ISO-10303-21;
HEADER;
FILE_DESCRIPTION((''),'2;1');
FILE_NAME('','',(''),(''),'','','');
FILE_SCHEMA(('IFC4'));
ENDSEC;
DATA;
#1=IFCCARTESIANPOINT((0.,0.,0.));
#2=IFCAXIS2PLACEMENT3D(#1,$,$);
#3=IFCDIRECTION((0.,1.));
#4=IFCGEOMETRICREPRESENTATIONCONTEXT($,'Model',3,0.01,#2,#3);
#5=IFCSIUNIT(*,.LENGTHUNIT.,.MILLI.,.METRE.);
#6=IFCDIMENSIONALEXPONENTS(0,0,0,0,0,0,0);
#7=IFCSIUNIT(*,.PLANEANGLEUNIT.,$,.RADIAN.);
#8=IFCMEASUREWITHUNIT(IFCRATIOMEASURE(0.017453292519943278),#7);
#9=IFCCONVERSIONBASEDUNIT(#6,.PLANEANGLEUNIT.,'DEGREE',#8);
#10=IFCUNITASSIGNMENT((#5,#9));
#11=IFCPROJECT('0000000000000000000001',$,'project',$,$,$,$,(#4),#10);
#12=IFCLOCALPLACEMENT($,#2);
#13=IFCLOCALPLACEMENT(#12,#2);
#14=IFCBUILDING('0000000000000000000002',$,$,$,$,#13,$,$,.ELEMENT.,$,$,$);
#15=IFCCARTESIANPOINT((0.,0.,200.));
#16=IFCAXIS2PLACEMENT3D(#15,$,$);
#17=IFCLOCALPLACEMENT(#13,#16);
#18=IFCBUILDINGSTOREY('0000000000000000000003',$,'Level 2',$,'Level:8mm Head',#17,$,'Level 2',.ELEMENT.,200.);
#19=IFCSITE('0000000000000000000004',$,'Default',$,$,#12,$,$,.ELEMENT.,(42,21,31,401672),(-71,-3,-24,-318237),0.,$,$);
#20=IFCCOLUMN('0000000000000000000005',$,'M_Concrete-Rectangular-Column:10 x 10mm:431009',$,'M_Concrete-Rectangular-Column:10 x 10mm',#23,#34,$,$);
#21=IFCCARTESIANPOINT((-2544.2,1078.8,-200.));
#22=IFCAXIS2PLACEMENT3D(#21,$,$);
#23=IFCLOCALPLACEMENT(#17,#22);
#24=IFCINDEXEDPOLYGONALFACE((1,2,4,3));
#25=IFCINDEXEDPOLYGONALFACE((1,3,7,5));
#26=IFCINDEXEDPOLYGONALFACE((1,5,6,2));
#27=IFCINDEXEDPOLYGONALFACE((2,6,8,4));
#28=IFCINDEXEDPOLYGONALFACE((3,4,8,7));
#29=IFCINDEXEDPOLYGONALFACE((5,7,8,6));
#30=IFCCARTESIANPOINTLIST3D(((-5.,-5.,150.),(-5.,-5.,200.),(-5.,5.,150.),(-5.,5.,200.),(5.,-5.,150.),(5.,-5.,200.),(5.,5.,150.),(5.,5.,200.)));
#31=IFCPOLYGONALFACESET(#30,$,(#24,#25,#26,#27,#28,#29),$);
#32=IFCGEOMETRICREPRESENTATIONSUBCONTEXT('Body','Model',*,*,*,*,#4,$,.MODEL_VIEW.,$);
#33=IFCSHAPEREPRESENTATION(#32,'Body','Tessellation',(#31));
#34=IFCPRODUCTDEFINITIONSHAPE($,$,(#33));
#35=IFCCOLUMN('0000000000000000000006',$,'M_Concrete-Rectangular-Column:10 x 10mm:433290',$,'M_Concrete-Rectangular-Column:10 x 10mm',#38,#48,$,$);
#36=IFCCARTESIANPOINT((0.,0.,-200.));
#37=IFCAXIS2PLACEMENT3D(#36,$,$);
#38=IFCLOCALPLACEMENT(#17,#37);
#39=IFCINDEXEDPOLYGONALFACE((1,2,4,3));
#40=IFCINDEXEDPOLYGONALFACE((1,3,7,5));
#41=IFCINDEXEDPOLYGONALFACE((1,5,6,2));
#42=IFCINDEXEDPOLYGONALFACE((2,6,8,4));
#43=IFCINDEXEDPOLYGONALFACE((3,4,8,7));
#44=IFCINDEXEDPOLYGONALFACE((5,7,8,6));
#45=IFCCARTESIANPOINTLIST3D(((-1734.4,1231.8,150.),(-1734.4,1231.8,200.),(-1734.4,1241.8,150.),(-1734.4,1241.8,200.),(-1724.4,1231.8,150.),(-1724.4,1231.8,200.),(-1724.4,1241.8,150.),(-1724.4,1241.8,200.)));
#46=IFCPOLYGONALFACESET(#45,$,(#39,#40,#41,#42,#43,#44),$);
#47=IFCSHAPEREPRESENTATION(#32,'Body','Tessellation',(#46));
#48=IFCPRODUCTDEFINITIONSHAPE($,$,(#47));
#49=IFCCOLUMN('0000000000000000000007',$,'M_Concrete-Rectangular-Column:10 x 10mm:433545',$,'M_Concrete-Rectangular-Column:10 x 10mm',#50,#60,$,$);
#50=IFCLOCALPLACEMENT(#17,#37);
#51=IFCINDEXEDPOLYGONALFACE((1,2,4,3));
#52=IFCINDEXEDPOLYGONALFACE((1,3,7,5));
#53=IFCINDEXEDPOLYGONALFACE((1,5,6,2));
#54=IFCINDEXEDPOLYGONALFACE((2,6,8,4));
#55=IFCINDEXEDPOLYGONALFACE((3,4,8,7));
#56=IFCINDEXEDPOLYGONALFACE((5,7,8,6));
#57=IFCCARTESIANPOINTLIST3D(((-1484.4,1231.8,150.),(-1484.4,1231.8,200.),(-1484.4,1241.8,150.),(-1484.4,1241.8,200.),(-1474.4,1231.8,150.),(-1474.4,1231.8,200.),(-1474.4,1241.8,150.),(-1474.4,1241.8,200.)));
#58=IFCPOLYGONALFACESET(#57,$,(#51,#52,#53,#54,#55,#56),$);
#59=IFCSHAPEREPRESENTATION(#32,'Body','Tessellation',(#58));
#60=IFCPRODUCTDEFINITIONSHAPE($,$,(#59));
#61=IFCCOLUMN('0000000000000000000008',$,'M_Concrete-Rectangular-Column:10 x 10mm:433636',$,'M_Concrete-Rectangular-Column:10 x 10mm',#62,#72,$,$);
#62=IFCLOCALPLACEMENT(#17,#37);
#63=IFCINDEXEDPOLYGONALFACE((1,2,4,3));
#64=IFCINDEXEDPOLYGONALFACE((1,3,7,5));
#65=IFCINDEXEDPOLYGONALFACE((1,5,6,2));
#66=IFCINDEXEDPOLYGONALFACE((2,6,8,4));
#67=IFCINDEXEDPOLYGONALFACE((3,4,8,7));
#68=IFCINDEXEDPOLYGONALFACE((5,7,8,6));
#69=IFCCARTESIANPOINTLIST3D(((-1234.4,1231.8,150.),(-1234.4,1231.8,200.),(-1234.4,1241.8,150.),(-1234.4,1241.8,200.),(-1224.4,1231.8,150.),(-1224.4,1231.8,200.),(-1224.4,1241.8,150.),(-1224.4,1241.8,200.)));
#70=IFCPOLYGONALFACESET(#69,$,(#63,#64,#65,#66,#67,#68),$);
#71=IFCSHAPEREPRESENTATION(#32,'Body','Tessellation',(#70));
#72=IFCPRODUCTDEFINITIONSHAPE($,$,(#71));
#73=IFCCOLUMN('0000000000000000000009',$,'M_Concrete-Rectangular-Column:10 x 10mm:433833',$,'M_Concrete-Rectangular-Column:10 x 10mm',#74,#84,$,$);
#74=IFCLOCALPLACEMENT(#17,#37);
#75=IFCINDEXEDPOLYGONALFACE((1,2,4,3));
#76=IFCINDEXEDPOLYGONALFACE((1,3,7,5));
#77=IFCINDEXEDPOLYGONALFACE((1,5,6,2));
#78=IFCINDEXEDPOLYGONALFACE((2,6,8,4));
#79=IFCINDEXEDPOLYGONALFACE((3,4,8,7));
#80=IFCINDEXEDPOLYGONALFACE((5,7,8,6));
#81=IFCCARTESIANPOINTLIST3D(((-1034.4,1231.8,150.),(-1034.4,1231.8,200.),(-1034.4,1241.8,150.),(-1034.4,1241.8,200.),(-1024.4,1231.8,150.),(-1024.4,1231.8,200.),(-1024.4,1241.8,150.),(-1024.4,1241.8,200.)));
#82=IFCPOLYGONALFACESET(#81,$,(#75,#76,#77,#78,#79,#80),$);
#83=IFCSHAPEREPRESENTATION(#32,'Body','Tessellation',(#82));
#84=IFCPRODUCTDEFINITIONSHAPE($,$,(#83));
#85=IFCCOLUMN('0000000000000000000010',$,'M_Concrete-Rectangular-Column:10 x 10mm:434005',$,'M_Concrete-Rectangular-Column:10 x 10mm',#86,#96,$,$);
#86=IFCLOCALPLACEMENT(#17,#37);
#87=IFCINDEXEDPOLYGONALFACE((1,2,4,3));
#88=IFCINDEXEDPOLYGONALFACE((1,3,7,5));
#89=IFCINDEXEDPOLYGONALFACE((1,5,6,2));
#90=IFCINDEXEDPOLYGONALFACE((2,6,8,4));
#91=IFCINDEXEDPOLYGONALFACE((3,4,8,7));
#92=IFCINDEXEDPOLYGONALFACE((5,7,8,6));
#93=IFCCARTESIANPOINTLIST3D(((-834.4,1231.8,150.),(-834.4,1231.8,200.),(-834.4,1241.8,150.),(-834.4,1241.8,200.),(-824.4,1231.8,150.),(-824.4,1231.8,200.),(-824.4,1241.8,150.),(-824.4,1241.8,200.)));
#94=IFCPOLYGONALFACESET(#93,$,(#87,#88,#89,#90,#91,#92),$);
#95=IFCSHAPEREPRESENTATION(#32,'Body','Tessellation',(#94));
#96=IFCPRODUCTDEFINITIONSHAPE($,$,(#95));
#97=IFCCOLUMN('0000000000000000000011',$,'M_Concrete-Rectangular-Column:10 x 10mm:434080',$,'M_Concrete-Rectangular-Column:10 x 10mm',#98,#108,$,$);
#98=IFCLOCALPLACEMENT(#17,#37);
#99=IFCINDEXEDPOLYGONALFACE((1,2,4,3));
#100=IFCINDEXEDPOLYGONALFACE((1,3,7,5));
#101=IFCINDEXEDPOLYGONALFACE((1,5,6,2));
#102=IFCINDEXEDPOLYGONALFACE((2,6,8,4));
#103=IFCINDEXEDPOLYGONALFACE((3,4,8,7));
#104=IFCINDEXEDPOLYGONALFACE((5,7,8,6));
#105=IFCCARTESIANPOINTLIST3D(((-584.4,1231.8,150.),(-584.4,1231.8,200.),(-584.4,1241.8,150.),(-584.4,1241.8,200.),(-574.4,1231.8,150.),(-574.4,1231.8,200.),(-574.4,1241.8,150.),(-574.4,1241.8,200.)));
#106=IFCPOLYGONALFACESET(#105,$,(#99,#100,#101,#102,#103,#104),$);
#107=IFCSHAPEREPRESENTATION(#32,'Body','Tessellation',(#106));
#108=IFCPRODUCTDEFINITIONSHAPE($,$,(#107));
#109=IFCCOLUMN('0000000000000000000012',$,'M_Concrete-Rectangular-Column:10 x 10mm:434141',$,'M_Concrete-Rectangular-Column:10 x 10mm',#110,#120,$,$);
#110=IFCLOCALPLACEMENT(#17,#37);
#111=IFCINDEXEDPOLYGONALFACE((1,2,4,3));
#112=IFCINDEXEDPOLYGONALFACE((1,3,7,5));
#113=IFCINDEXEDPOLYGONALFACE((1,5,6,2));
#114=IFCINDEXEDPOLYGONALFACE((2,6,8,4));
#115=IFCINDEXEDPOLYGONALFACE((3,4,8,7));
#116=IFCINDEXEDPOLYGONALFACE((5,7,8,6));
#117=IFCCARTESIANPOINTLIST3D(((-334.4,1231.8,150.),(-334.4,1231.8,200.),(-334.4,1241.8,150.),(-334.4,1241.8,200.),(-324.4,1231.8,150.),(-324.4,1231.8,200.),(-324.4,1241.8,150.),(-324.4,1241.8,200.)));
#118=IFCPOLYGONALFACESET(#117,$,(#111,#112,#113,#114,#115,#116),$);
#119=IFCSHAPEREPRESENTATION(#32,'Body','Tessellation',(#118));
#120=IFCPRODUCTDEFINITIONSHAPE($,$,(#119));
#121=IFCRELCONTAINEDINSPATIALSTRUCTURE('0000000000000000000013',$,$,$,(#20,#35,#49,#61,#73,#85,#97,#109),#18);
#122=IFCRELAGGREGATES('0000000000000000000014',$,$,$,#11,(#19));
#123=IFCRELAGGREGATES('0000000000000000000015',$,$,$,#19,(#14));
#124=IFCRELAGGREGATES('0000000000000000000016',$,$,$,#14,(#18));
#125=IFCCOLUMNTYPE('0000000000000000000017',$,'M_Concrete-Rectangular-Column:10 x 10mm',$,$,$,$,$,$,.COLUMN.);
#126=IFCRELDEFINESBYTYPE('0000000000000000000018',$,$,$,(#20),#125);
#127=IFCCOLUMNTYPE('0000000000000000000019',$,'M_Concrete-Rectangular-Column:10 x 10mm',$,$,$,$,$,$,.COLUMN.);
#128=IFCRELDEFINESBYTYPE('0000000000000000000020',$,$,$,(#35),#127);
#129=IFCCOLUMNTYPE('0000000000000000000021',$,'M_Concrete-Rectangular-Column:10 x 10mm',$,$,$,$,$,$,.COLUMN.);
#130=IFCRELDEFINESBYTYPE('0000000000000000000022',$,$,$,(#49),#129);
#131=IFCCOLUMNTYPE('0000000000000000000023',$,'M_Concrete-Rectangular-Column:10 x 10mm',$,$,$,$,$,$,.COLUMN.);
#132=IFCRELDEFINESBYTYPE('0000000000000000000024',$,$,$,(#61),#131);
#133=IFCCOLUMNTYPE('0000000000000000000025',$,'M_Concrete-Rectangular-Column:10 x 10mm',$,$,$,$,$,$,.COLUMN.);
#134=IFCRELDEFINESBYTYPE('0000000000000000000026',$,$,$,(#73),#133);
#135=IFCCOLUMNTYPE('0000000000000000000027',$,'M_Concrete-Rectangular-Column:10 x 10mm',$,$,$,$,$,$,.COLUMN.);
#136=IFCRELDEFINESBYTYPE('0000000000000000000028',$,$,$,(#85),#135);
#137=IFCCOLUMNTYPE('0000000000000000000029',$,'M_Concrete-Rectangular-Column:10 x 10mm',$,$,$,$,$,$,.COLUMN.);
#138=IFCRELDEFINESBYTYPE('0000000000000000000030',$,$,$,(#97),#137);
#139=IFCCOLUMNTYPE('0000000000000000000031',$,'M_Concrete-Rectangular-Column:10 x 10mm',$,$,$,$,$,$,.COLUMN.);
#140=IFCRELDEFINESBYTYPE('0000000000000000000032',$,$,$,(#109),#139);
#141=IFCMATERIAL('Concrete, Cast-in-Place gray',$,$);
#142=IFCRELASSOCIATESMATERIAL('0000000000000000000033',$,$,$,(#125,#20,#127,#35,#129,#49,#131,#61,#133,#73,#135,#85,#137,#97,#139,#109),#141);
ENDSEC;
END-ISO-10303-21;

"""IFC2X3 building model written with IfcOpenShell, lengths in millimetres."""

from ifc_helpers import new_model, entity, si_unit, converted_unit, direction, frame, frame_2d, origin, origin_2d_with_axis, place, context, subcontext, project, spatial, rectangle, extrude, source, transform, mapped, material, type_object, type_shapes, element, save


model = new_model("IFC2X3")

# Units and contexts
model_context = context("Model", 3, precision=0.01, world=origin(), true_north=direction((0.0, 1.0)))
body_context = subcontext(model_context, "Body", "Model", "MODEL_VIEW")
ifc_project = project(units=[si_unit("LENGTHUNIT", "METRE", prefix="MILLI"), converted_unit("PLANEANGLEUNIT", "DEGREE", entity("IfcRatioMeasure", 0.017453292519943278), si_unit("PLANEANGLEUNIT", "RADIAN"), dimensions=[0, 0, 0, 0, 0, 0, 0])], contexts=[model_context])

# Site, building, storey
site_placement = place(None, origin())
site = spatial("IfcSite", under=ifc_project, at=site_placement, Name="Default", CompositionType="ELEMENT", RefLatitude=(42, 21, 31, 401672), RefLongitude=(-71, -3, -24, -318237), RefElevation=0.0)
building_placement = place(site_placement, origin())
building = spatial("IfcBuilding", under=site, at=building_placement, CompositionType="ELEMENT")
storey_placement = place(building_placement, frame((0.0, 0.0, 200.0)))
storey = spatial("IfcBuildingStorey", under=building, at=storey_placement, Name="Level 2", ObjectType="Level:8mm Head", LongName="Level 2", CompositionType="ELEMENT", Elevation=200.0)

# Columns
ifc_material = material(Name="Concrete, Cast-in-Place gray")
column_type_1 = type_object("IfcColumnType", Name="M_Concrete-Rectangular-Column:10 x 10mm", PredefinedType="COLUMN", material=ifc_material)
shared_shape_1 = source(origin(), body_context, "Body", "SweptSolid", [
    extrude(rectangle(XDim=10.0, YDim=10.0, at=origin_2d_with_axis()), frame((0.0, 0.0, 150.0), z_axis=(0.0, 0.0, 1.0), x_axis=(0.0, -1.0, 0.0)), (0.0, 0.0, 1.0), 50.0),
])
type_shapes(column_type_1, [shared_shape_1])
column_1_placement = place(storey_placement, frame((-2544.2, 1078.8, -200.0)))
element("IfcColumn", 1, at=column_1_placement, inside=storey, type_object=column_type_1, material=ifc_material, Name="M_Concrete-Rectangular-Column:10 x 10mm:431009", ObjectType="M_Concrete-Rectangular-Column:10 x 10mm", context=body_context, shape_type="MappedRepresentation", body=[
    mapped(shared_shape_1, transform((0.0, 0.0, 0.0), scale=1.0)),
])
column_type_2 = type_object("IfcColumnType", Name="M_Concrete-Rectangular-Column:10 x 10mm", PredefinedType="COLUMN", material=ifc_material)
shared_shape_2 = source(origin(), body_context, "Body", "SweptSolid", [
    extrude(rectangle(XDim=10.0, YDim=10.0, at=frame_2d((0.0, 0.0), x_axis=(1.0, 0.0))), frame((-1729.4, 1236.8, 150.0), z_axis=(0.0, 0.0, 1.0), x_axis=(0.0, -1.0, 0.0)), (0.0, 0.0, 1.0), 50.0),
])
type_shapes(column_type_2, [shared_shape_2])
column_2_placement = place(storey_placement, frame((0.0, 0.0, -200.0)))
element("IfcColumn", 2, at=column_2_placement, inside=storey, type_object=column_type_2, material=ifc_material, Name="M_Concrete-Rectangular-Column:10 x 10mm:433290", ObjectType="M_Concrete-Rectangular-Column:10 x 10mm", context=body_context, shape_type="MappedRepresentation", body=[
    mapped(shared_shape_2, transform((0.0, 0.0, 0.0), scale=1.0)),
])
column_type_3 = type_object("IfcColumnType", Name="M_Concrete-Rectangular-Column:10 x 10mm", PredefinedType="COLUMN", material=ifc_material)
shared_shape_3 = source(origin(), body_context, "Body", "SweptSolid", [
    extrude(rectangle(XDim=10.0, YDim=10.0, at=frame_2d((0.0, 0.0), x_axis=(1.0, 0.0))), frame((-1479.4, 1236.8, 150.0), z_axis=(0.0, 0.0, 1.0), x_axis=(0.0, -1.0, 0.0)), (0.0, 0.0, 1.0), 50.0),
])
type_shapes(column_type_3, [shared_shape_3])
column_3_placement = place(storey_placement, frame((0.0, 0.0, -200.0)))
element("IfcColumn", 3, at=column_3_placement, inside=storey, type_object=column_type_3, material=ifc_material, Name="M_Concrete-Rectangular-Column:10 x 10mm:433545", ObjectType="M_Concrete-Rectangular-Column:10 x 10mm", context=body_context, shape_type="MappedRepresentation", body=[
    mapped(shared_shape_3, transform((0.0, 0.0, 0.0), scale=1.0)),
])
column_type_4 = type_object("IfcColumnType", Name="M_Concrete-Rectangular-Column:10 x 10mm", PredefinedType="COLUMN", material=ifc_material)
shared_shape_4 = source(origin(), body_context, "Body", "SweptSolid", [
    extrude(rectangle(XDim=10.0, YDim=10.0, at=frame_2d((0.0, 0.0), x_axis=(1.0, 0.0))), frame((-1229.4, 1236.8, 150.0), z_axis=(0.0, 0.0, 1.0), x_axis=(0.0, -1.0, 0.0)), (0.0, 0.0, 1.0), 50.0),
])
type_shapes(column_type_4, [shared_shape_4])
column_4_placement = place(storey_placement, frame((0.0, 0.0, -200.0)))
element("IfcColumn", 4, at=column_4_placement, inside=storey, type_object=column_type_4, material=ifc_material, Name="M_Concrete-Rectangular-Column:10 x 10mm:433636", ObjectType="M_Concrete-Rectangular-Column:10 x 10mm", context=body_context, shape_type="MappedRepresentation", body=[
    mapped(shared_shape_4, transform((0.0, 0.0, 0.0), scale=1.0)),
])
column_type_5 = type_object("IfcColumnType", Name="M_Concrete-Rectangular-Column:10 x 10mm", PredefinedType="COLUMN", material=ifc_material)
shared_shape_5 = source(origin(), body_context, "Body", "SweptSolid", [
    extrude(rectangle(XDim=10.0, YDim=10.0, at=origin_2d_with_axis()), frame((-1029.4, 1236.8, 150.0), z_axis=(0.0, 0.0, 1.0), x_axis=(0.0, -1.0, 0.0)), (0.0, 0.0, 1.0), 50.0),
])
type_shapes(column_type_5, [shared_shape_5])
column_5_placement = place(storey_placement, frame((0.0, 0.0, -200.0)))
element("IfcColumn", 5, at=column_5_placement, inside=storey, type_object=column_type_5, material=ifc_material, Name="M_Concrete-Rectangular-Column:10 x 10mm:433833", ObjectType="M_Concrete-Rectangular-Column:10 x 10mm", context=body_context, shape_type="MappedRepresentation", body=[
    mapped(shared_shape_5, transform((0.0, 0.0, 0.0), scale=1.0)),
])
column_type_6 = type_object("IfcColumnType", Name="M_Concrete-Rectangular-Column:10 x 10mm", PredefinedType="COLUMN", material=ifc_material)
shared_shape_6 = source(origin(), body_context, "Body", "SweptSolid", [
    extrude(rectangle(XDim=10.0, YDim=10.0, at=origin_2d_with_axis()), frame((-829.4, 1236.8, 150.0), z_axis=(0.0, 0.0, 1.0), x_axis=(0.0, -1.0, 0.0)), (0.0, 0.0, 1.0), 50.0),
])
type_shapes(column_type_6, [shared_shape_6])
column_6_placement = place(storey_placement, frame((0.0, 0.0, -200.0)))
element("IfcColumn", 6, at=column_6_placement, inside=storey, type_object=column_type_6, material=ifc_material, Name="M_Concrete-Rectangular-Column:10 x 10mm:434005", ObjectType="M_Concrete-Rectangular-Column:10 x 10mm", context=body_context, shape_type="MappedRepresentation", body=[
    mapped(shared_shape_6, transform((0.0, 0.0, 0.0), scale=1.0)),
])
column_type_7 = type_object("IfcColumnType", Name="M_Concrete-Rectangular-Column:10 x 10mm", PredefinedType="COLUMN", material=ifc_material)
shared_shape_7 = source(origin(), body_context, "Body", "SweptSolid", [
    extrude(rectangle(XDim=10.0, YDim=10.0, at=frame_2d((0.0, 0.0), x_axis=(1.0, 0.0))), frame((-579.4, 1236.8, 150.0), z_axis=(0.0, 0.0, 1.0), x_axis=(0.0, -1.0, 0.0)), (0.0, 0.0, 1.0), 50.0),
])
type_shapes(column_type_7, [shared_shape_7])
column_7_placement = place(storey_placement, frame((0.0, 0.0, -200.0)))
element("IfcColumn", 7, at=column_7_placement, inside=storey, type_object=column_type_7, material=ifc_material, Name="M_Concrete-Rectangular-Column:10 x 10mm:434080", ObjectType="M_Concrete-Rectangular-Column:10 x 10mm", context=body_context, shape_type="MappedRepresentation", body=[
    mapped(shared_shape_7, transform((0.0, 0.0, 0.0), scale=1.0)),
])
column_type_8 = type_object("IfcColumnType", Name="M_Concrete-Rectangular-Column:10 x 10mm", PredefinedType="COLUMN", material=ifc_material)
shared_shape_8 = source(origin(), body_context, "Body", "SweptSolid", [
    extrude(rectangle(XDim=10.0, YDim=10.0, at=frame_2d((0.0, 0.0), x_axis=(1.0, 0.0))), frame((-329.4, 1236.8, 150.0), z_axis=(0.0, 0.0, 1.0), x_axis=(0.0, -1.0, 0.0)), (0.0, 0.0, 1.0), 50.0),
])
type_shapes(column_type_8, [shared_shape_8])
column_8_placement = place(storey_placement, frame((0.0, 0.0, -200.0)))
element("IfcColumn", 8, at=column_8_placement, inside=storey, type_object=column_type_8, material=ifc_material, Name="M_Concrete-Rectangular-Column:10 x 10mm:434141", ObjectType="M_Concrete-Rectangular-Column:10 x 10mm", context=body_context, shape_type="MappedRepresentation", body=[
    mapped(shared_shape_8, transform((0.0, 0.0, 0.0), scale=1.0)),
])

save(model, "model.ifc")
